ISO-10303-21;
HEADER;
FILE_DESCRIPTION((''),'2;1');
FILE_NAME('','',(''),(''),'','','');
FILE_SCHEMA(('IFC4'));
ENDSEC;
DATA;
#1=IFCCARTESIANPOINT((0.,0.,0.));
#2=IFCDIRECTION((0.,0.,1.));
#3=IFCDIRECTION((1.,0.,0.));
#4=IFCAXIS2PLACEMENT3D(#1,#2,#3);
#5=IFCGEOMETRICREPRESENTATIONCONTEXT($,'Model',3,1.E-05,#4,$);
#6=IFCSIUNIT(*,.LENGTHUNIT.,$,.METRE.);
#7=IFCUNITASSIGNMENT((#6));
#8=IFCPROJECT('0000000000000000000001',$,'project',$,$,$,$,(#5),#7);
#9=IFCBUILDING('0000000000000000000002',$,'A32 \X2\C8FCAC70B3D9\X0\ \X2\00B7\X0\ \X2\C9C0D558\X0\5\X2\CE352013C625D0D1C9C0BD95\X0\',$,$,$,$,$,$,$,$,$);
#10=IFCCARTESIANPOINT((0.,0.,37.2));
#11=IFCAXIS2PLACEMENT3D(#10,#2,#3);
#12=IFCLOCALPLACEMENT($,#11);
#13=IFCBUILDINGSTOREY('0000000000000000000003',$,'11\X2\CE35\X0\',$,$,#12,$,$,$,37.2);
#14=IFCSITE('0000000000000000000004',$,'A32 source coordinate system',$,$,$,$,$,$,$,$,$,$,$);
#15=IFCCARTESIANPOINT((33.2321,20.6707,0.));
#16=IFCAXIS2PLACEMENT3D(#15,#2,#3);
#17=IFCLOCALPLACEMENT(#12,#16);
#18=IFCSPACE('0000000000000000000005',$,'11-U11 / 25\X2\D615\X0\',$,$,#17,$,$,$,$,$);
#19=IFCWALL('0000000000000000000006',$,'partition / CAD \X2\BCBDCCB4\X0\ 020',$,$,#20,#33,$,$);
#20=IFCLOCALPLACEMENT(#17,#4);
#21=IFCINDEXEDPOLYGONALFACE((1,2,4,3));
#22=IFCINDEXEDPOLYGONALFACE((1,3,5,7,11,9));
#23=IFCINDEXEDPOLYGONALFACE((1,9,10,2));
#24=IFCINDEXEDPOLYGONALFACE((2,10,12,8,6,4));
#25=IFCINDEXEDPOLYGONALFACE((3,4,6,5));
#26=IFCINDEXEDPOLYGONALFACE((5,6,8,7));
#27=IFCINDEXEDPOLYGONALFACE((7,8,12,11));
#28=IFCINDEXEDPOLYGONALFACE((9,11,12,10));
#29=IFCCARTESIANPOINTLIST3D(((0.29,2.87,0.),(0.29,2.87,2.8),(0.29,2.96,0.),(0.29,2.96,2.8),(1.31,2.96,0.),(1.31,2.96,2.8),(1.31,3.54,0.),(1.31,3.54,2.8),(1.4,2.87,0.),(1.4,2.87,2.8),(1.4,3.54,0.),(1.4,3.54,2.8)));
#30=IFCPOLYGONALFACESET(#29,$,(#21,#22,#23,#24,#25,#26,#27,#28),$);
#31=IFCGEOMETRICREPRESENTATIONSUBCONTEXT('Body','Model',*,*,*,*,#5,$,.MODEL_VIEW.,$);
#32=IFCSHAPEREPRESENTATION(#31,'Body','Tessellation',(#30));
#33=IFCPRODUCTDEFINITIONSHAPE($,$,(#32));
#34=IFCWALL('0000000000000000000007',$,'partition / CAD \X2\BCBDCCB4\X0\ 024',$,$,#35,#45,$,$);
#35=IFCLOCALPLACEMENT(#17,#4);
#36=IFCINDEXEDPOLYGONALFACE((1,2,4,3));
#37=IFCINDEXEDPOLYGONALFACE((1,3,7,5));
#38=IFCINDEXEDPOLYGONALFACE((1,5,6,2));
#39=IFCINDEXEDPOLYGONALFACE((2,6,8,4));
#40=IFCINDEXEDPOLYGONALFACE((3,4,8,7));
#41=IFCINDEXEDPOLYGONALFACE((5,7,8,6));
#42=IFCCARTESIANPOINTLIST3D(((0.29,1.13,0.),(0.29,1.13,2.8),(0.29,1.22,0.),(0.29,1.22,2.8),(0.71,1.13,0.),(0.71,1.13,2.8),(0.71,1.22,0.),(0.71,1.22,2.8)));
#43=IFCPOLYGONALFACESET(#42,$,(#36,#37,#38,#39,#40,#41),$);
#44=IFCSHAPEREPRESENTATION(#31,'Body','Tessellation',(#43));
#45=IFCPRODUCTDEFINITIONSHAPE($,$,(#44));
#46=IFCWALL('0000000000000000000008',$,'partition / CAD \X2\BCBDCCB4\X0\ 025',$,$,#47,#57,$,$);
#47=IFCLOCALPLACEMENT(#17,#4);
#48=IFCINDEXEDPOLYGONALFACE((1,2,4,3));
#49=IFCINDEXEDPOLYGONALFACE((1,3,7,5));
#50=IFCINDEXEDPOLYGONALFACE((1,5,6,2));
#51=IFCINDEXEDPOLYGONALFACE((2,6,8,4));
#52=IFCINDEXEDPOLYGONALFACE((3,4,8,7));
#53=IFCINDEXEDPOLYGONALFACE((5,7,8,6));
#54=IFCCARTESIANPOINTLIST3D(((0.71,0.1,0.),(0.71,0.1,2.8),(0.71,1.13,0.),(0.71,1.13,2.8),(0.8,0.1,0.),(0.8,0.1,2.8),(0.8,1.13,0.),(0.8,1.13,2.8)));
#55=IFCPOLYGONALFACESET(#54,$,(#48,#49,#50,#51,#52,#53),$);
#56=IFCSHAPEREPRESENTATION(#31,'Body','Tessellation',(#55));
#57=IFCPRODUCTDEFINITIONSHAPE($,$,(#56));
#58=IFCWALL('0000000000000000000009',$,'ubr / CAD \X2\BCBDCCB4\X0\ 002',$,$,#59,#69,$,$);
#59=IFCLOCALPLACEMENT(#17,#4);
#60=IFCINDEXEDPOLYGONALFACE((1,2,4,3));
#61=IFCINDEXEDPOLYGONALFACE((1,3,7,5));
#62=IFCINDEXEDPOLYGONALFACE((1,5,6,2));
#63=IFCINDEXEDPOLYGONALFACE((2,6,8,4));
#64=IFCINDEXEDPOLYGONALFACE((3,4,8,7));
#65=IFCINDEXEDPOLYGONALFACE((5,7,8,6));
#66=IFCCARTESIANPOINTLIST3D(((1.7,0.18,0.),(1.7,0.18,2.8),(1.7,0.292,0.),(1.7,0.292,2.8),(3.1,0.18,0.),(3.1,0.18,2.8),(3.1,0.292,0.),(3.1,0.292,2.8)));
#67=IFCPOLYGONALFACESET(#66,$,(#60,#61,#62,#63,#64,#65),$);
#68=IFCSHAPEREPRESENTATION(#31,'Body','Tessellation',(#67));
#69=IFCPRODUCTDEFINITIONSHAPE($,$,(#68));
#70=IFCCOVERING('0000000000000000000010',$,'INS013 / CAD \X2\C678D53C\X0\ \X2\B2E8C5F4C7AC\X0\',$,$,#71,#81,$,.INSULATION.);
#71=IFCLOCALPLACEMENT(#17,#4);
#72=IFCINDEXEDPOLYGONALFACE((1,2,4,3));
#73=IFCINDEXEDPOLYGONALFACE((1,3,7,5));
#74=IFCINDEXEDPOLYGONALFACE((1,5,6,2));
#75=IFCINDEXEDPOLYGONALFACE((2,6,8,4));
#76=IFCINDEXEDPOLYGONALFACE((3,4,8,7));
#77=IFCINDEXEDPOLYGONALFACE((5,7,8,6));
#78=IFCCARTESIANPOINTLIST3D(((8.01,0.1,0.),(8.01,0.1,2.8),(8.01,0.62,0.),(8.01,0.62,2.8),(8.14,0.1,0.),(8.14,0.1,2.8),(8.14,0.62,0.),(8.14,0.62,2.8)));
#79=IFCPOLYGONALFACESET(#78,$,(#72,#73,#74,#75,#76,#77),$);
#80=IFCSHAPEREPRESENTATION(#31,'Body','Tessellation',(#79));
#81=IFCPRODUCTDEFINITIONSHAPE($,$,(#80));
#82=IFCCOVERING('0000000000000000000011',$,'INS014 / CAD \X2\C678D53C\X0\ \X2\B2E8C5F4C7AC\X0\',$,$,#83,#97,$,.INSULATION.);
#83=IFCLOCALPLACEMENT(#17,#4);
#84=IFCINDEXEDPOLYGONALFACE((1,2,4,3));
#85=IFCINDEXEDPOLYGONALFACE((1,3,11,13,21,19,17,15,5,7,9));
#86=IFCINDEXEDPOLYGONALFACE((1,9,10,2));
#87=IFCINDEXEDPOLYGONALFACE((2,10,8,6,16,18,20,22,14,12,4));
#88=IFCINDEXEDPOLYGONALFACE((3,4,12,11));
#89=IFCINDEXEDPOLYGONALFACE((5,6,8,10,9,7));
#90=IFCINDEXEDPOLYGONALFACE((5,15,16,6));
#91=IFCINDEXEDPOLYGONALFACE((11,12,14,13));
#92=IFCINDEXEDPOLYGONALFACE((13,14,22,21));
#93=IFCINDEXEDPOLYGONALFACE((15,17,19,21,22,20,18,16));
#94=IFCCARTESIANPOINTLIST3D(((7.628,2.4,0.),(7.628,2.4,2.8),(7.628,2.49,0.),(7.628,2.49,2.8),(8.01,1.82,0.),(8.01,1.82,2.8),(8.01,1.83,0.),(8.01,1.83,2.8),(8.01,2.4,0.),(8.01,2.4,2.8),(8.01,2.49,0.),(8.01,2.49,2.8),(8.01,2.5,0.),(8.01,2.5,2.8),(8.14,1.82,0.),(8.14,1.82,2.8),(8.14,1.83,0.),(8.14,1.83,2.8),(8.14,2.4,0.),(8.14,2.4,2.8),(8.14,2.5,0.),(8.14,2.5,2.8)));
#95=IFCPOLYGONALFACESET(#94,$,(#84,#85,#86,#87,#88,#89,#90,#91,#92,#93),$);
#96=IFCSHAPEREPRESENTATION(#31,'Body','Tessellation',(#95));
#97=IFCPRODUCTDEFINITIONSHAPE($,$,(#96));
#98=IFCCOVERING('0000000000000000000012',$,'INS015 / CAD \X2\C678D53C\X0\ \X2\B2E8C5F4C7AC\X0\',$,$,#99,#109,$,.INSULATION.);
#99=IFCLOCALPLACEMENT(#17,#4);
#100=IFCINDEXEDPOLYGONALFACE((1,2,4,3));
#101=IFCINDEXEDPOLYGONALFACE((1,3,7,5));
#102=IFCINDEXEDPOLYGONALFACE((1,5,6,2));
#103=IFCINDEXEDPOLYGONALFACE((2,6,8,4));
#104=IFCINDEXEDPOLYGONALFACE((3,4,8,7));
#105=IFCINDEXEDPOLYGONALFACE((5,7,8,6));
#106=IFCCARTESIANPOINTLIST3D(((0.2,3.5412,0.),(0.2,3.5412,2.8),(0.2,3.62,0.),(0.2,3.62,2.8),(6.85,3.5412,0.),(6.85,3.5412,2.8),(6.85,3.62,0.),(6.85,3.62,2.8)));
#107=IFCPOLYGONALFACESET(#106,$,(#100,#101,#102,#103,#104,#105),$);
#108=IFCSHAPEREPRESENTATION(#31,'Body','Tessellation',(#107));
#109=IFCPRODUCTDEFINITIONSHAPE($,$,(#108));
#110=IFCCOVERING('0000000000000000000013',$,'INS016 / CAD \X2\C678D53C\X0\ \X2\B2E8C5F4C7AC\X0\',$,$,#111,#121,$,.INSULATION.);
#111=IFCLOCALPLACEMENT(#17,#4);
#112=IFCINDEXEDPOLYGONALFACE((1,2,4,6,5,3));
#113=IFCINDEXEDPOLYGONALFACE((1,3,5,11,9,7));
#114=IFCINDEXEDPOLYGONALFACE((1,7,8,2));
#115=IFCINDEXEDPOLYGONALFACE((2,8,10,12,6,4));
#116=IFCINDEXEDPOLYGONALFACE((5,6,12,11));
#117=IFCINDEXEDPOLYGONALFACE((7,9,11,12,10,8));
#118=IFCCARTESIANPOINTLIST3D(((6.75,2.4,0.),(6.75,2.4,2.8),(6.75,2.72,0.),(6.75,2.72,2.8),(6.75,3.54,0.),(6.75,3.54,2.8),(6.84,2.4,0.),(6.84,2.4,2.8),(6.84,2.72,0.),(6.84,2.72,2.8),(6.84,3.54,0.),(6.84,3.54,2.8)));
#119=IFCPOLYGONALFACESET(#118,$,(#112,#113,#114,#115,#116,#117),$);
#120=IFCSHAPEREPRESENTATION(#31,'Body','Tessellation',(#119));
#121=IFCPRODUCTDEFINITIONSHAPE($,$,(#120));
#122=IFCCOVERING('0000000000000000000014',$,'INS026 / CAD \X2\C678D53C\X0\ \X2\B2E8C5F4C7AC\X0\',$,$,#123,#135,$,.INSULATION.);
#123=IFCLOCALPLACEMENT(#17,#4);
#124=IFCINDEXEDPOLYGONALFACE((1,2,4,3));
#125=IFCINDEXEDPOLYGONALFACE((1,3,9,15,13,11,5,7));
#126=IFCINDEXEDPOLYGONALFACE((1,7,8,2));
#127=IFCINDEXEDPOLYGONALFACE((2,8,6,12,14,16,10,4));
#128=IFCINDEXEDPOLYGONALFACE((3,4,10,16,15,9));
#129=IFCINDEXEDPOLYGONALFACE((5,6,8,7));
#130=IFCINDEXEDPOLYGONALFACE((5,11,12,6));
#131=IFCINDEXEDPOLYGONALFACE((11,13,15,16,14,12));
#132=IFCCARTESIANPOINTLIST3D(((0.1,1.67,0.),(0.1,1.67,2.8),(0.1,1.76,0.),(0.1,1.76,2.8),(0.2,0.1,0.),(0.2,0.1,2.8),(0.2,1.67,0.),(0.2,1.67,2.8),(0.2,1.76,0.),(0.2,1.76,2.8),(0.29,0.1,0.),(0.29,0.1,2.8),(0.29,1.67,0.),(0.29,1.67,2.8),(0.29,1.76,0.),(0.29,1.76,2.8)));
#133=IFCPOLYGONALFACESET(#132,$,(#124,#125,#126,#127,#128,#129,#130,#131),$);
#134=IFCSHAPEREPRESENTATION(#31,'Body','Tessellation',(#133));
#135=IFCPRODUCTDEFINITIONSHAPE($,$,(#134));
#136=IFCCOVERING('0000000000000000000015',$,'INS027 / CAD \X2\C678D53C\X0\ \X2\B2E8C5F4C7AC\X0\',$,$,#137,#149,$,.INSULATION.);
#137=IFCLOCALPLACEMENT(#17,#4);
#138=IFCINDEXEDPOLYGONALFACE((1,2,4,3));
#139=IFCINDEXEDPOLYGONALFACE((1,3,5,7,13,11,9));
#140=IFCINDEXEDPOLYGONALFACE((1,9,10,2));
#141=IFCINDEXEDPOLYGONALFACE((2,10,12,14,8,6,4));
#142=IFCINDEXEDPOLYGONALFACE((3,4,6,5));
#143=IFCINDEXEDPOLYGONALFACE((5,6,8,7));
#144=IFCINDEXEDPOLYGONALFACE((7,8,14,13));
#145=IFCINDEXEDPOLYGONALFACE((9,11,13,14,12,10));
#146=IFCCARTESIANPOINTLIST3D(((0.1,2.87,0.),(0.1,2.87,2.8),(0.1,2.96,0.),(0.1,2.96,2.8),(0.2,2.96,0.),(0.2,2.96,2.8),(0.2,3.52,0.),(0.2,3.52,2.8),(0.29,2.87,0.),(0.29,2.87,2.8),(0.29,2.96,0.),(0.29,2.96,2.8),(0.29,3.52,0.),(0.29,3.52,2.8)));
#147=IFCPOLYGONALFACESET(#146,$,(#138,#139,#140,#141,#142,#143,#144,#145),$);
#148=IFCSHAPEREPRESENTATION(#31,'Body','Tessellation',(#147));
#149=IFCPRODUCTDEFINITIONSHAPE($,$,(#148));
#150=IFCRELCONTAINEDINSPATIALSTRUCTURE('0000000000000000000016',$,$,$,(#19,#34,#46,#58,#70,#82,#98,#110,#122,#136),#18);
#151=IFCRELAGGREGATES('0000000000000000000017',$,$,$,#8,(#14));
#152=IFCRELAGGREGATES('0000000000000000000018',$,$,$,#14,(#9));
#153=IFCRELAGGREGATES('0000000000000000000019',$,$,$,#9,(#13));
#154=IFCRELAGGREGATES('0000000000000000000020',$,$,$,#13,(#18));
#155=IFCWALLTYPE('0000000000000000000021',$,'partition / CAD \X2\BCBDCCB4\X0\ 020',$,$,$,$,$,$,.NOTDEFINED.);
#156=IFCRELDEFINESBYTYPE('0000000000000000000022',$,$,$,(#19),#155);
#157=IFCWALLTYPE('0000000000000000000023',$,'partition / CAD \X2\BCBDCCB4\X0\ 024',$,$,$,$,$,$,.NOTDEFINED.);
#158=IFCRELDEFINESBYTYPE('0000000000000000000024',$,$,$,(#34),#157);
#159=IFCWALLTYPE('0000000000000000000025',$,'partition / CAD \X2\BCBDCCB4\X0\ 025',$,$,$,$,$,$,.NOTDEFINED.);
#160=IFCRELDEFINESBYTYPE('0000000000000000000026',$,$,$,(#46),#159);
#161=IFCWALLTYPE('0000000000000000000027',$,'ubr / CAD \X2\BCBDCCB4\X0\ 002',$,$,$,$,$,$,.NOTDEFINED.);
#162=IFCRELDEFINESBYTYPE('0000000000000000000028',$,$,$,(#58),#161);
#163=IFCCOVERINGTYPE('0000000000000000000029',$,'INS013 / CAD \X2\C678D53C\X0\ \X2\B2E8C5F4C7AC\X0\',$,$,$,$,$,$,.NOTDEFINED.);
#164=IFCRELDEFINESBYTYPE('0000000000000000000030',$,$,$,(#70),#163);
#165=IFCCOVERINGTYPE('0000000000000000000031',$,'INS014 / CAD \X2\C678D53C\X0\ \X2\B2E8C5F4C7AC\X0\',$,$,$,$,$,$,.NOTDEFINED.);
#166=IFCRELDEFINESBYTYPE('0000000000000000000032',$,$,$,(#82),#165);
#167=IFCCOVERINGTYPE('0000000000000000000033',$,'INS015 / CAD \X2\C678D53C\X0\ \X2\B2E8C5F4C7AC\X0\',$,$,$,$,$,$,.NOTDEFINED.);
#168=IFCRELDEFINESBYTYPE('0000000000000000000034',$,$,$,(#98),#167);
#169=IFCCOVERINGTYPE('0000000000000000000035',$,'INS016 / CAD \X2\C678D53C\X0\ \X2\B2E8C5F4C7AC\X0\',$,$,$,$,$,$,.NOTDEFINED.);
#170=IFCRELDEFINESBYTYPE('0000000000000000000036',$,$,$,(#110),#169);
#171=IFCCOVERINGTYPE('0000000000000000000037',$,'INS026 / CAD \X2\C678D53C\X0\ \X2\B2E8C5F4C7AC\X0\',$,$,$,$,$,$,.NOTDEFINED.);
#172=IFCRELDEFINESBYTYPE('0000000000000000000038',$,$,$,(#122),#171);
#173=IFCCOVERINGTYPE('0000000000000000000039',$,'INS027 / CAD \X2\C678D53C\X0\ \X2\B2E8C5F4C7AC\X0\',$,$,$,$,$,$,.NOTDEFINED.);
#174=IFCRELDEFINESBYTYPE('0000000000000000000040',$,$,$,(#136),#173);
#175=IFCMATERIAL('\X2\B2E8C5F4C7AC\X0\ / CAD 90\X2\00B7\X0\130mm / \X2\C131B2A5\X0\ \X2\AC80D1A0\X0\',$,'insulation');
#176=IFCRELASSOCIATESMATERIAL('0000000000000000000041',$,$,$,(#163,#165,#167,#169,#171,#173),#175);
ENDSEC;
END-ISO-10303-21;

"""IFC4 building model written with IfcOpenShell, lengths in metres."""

from ifc_helpers import new_model, si_unit, frame, origin, origin_with_axes, place, context, subcontext, project, spatial, polyline, outline, extrude, source, transform, mapped, material, type_object, type_shapes, element, save


model = new_model("IFC4")

# Units and contexts
model_context = context("Model", 3, precision=1e-05, world=origin_with_axes())
body_context = subcontext(model_context, "Body", "Model", "MODEL_VIEW")
ifc_project = project(units=[si_unit("LENGTHUNIT", "METRE")], contexts=[model_context])

# Site, building, storey, space
storey_placement = place(None, frame((0.0, 0.0, 37.2), z_axis=(0.0, 0.0, 1.0), x_axis=(1.0, 0.0, 0.0)))
space_placement = place(storey_placement, frame((33.2321, 20.6707, 0.0), z_axis=(0.0, 0.0, 1.0), x_axis=(1.0, 0.0, 0.0)))
site = spatial("IfcSite", under=ifc_project, Name="A32 source coordinate system")
building = spatial("IfcBuilding", under=site, Name="A32 주거동 · 지하5층–옥탑지붕")
storey = spatial("IfcBuildingStorey", under=building, at=storey_placement, Name="11층", Elevation=37.2)
space = spatial("IfcSpace", under=storey, at=space_placement, Name="11-U11 / 25형")

# Walls
wall_type_1 = type_object("IfcWallType", Name="partition / CAD 벽체 020", PredefinedType="NOTDEFINED")
shared_shape_1 = source(origin(), body_context, "Body", "SweptSolid", [
    extrude(outline(polyline([(0.29, 2.87), (0.29, 2.96), (1.31, 2.96), (1.31, 3.54), (1.4, 3.54), (1.4, 2.87), (0.29, 2.87)])), origin(), (0.0, 0.0, 1.0), 2.8),
])
type_shapes(wall_type_1, [shared_shape_1])
wall_1_placement = place(space_placement, origin_with_axes())
element("IfcWall", 1, at=wall_1_placement, inside=space, type_object=wall_type_1, Name="partition / CAD 벽체 020", context=body_context, shape_type="MappedRepresentation", body=[
    mapped(shared_shape_1, transform((0.0, 0.0, 0.0), scale=1.0)),
])
wall_type_2 = type_object("IfcWallType", Name="partition / CAD 벽체 024", PredefinedType="NOTDEFINED")
shared_shape_2 = source(origin(), body_context, "Body", "SweptSolid", [
    extrude(outline(polyline([(0.71, 1.13), (0.29, 1.13), (0.29, 1.22), (0.71, 1.22), (0.71, 1.13)])), origin(), (0.0, 0.0, 1.0), 2.8),
])
type_shapes(wall_type_2, [shared_shape_2])
wall_2_placement = place(space_placement, origin_with_axes())
element("IfcWall", 2, at=wall_2_placement, inside=space, type_object=wall_type_2, Name="partition / CAD 벽체 024", context=body_context, shape_type="MappedRepresentation", body=[
    mapped(shared_shape_2, transform((0.0, 0.0, 0.0), scale=1.0)),
])
wall_type_3 = type_object("IfcWallType", Name="partition / CAD 벽체 025", PredefinedType="NOTDEFINED")
shared_shape_3 = source(origin(), body_context, "Body", "SweptSolid", [
    extrude(outline(polyline([(0.71, 1.13), (0.8, 1.13), (0.8, 0.1), (0.71, 0.1), (0.71, 1.13)])), origin(), (0.0, 0.0, 1.0), 2.8),
])
type_shapes(wall_type_3, [shared_shape_3])
wall_3_placement = place(space_placement, origin_with_axes())
element("IfcWall", 3, at=wall_3_placement, inside=space, type_object=wall_type_3, Name="partition / CAD 벽체 025", context=body_context, shape_type="MappedRepresentation", body=[
    mapped(shared_shape_3, transform((0.0, 0.0, 0.0), scale=1.0)),
])
wall_type_4 = type_object("IfcWallType", Name="ubr / CAD 벽체 002", PredefinedType="NOTDEFINED")
shared_shape_4 = source(origin(), body_context, "Body", "SweptSolid", [
    extrude(outline(polyline([(3.1, 0.292), (3.1, 0.18), (1.7, 0.18), (1.7, 0.292), (3.1, 0.292)])), origin(), (0.0, 0.0, 1.0), 2.8),
])
type_shapes(wall_type_4, [shared_shape_4])
wall_4_placement = place(space_placement, origin_with_axes())
element("IfcWall", 4, at=wall_4_placement, inside=space, type_object=wall_type_4, Name="ubr / CAD 벽체 002", context=body_context, shape_type="MappedRepresentation", body=[
    mapped(shared_shape_4, transform((0.0, 0.0, 0.0), scale=1.0)),
])

# Coverings
ifc_material = material(Name="단열재 / CAD 90·130mm / 성능 검토", Category="insulation")
covering_type_1 = type_object("IfcCoveringType", Name="INS013 / CAD 외피 단열재", PredefinedType="NOTDEFINED", material=ifc_material)
shared_shape_5 = source(origin(), body_context, "Body", "SweptSolid", [
    extrude(outline(polyline([(8.14, 0.1), (8.01, 0.1), (8.01, 0.62), (8.14, 0.62), (8.14, 0.1)])), origin(), (0.0, 0.0, 1.0), 2.8),
])
type_shapes(covering_type_1, [shared_shape_5])
covering_1_placement = place(space_placement, origin_with_axes())
element("IfcCovering", 5, at=covering_1_placement, inside=space, type_object=covering_type_1, Name="INS013 / CAD 외피 단열재", PredefinedType="INSULATION", context=body_context, shape_type="MappedRepresentation", body=[
    mapped(shared_shape_5, transform((0.0, 0.0, 0.0), scale=1.0)),
])
covering_type_2 = type_object("IfcCoveringType", Name="INS014 / CAD 외피 단열재", PredefinedType="NOTDEFINED", material=ifc_material)
shared_shape_6 = source(origin(), body_context, "Body", "SweptSolid", [
    extrude(outline(polyline([(8.14, 2.5), (8.14, 2.4), (8.14, 1.83), (8.14, 1.82), (8.01, 1.82), (8.01, 1.83), (8.01, 2.4), (7.628, 2.4), (7.628, 2.49), (8.01, 2.49), (8.01, 2.5), (8.14, 2.5)])), origin(), (0.0, 0.0, 1.0), 2.8),
])
type_shapes(covering_type_2, [shared_shape_6])
covering_2_placement = place(space_placement, origin_with_axes())
element("IfcCovering", 6, at=covering_2_placement, inside=space, type_object=covering_type_2, Name="INS014 / CAD 외피 단열재", PredefinedType="INSULATION", context=body_context, shape_type="MappedRepresentation", body=[
    mapped(shared_shape_6, transform((0.0, 0.0, 0.0), scale=1.0)),
])
covering_type_3 = type_object("IfcCoveringType", Name="INS015 / CAD 외피 단열재", PredefinedType="NOTDEFINED", material=ifc_material)
shared_shape_7 = source(origin(), body_context, "Body", "SweptSolid", [
    extrude(outline(polyline([(0.2, 3.5412), (0.2, 3.62), (6.85, 3.62), (6.85, 3.5412), (0.2, 3.5412)])), origin(), (0.0, 0.0, 1.0), 2.8),
])
type_shapes(covering_type_3, [shared_shape_7])
covering_3_placement = place(space_placement, origin_with_axes())
element("IfcCovering", 7, at=covering_3_placement, inside=space, type_object=covering_type_3, Name="INS015 / CAD 외피 단열재", PredefinedType="INSULATION", context=body_context, shape_type="MappedRepresentation", body=[
    mapped(shared_shape_7, transform((0.0, 0.0, 0.0), scale=1.0)),
])
covering_type_4 = type_object("IfcCoveringType", Name="INS016 / CAD 외피 단열재", PredefinedType="NOTDEFINED", material=ifc_material)
shared_shape_8 = source(origin(), body_context, "Body", "SweptSolid", [
    extrude(outline(polyline([(6.84, 2.72), (6.84, 2.4), (6.75, 2.4), (6.75, 2.72), (6.75, 3.54), (6.84, 3.54), (6.84, 2.72)])), origin(), (0.0, 0.0, 1.0), 2.8),
])
type_shapes(covering_type_4, [shared_shape_8])
covering_4_placement = place(space_placement, origin_with_axes())
element("IfcCovering", 8, at=covering_4_placement, inside=space, type_object=covering_type_4, Name="INS016 / CAD 외피 단열재", PredefinedType="INSULATION", context=body_context, shape_type="MappedRepresentation", body=[
    mapped(shared_shape_8, transform((0.0, 0.0, 0.0), scale=1.0)),
])
covering_type_5 = type_object("IfcCoveringType", Name="INS026 / CAD 외피 단열재", PredefinedType="NOTDEFINED", material=ifc_material)
shared_shape_9 = source(origin(), body_context, "Body", "SweptSolid", [
    extrude(outline(polyline([(0.2, 1.76), (0.29, 1.76), (0.29, 1.67), (0.29, 0.1), (0.2, 0.1), (0.2, 1.67), (0.1, 1.67), (0.1, 1.76), (0.2, 1.76)])), origin(), (0.0, 0.0, 1.0), 2.8),
])
type_shapes(covering_type_5, [shared_shape_9])
covering_5_placement = place(space_placement, origin_with_axes())
element("IfcCovering", 9, at=covering_5_placement, inside=space, type_object=covering_type_5, Name="INS026 / CAD 외피 단열재", PredefinedType="INSULATION", context=body_context, shape_type="MappedRepresentation", body=[
    mapped(shared_shape_9, transform((0.0, 0.0, 0.0), scale=1.0)),
])
covering_type_6 = type_object("IfcCoveringType", Name="INS027 / CAD 외피 단열재", PredefinedType="NOTDEFINED", material=ifc_material)
shared_shape_10 = source(origin(), body_context, "Body", "SweptSolid", [
    extrude(outline(polyline([(0.2, 3.52), (0.29, 3.52), (0.29, 2.96), (0.29, 2.87), (0.1, 2.87), (0.1, 2.96), (0.2, 2.96), (0.2, 3.52)])), origin(), (0.0, 0.0, 1.0), 2.8),
])
type_shapes(covering_type_6, [shared_shape_10])
covering_6_placement = place(space_placement, origin_with_axes())
element("IfcCovering", 10, at=covering_6_placement, inside=space, type_object=covering_type_6, Name="INS027 / CAD 외피 단열재", PredefinedType="INSULATION", context=body_context, shape_type="MappedRepresentation", body=[
    mapped(shared_shape_10, transform((0.0, 0.0, 0.0), scale=1.0)),
])

save(model, "model.ifc")
